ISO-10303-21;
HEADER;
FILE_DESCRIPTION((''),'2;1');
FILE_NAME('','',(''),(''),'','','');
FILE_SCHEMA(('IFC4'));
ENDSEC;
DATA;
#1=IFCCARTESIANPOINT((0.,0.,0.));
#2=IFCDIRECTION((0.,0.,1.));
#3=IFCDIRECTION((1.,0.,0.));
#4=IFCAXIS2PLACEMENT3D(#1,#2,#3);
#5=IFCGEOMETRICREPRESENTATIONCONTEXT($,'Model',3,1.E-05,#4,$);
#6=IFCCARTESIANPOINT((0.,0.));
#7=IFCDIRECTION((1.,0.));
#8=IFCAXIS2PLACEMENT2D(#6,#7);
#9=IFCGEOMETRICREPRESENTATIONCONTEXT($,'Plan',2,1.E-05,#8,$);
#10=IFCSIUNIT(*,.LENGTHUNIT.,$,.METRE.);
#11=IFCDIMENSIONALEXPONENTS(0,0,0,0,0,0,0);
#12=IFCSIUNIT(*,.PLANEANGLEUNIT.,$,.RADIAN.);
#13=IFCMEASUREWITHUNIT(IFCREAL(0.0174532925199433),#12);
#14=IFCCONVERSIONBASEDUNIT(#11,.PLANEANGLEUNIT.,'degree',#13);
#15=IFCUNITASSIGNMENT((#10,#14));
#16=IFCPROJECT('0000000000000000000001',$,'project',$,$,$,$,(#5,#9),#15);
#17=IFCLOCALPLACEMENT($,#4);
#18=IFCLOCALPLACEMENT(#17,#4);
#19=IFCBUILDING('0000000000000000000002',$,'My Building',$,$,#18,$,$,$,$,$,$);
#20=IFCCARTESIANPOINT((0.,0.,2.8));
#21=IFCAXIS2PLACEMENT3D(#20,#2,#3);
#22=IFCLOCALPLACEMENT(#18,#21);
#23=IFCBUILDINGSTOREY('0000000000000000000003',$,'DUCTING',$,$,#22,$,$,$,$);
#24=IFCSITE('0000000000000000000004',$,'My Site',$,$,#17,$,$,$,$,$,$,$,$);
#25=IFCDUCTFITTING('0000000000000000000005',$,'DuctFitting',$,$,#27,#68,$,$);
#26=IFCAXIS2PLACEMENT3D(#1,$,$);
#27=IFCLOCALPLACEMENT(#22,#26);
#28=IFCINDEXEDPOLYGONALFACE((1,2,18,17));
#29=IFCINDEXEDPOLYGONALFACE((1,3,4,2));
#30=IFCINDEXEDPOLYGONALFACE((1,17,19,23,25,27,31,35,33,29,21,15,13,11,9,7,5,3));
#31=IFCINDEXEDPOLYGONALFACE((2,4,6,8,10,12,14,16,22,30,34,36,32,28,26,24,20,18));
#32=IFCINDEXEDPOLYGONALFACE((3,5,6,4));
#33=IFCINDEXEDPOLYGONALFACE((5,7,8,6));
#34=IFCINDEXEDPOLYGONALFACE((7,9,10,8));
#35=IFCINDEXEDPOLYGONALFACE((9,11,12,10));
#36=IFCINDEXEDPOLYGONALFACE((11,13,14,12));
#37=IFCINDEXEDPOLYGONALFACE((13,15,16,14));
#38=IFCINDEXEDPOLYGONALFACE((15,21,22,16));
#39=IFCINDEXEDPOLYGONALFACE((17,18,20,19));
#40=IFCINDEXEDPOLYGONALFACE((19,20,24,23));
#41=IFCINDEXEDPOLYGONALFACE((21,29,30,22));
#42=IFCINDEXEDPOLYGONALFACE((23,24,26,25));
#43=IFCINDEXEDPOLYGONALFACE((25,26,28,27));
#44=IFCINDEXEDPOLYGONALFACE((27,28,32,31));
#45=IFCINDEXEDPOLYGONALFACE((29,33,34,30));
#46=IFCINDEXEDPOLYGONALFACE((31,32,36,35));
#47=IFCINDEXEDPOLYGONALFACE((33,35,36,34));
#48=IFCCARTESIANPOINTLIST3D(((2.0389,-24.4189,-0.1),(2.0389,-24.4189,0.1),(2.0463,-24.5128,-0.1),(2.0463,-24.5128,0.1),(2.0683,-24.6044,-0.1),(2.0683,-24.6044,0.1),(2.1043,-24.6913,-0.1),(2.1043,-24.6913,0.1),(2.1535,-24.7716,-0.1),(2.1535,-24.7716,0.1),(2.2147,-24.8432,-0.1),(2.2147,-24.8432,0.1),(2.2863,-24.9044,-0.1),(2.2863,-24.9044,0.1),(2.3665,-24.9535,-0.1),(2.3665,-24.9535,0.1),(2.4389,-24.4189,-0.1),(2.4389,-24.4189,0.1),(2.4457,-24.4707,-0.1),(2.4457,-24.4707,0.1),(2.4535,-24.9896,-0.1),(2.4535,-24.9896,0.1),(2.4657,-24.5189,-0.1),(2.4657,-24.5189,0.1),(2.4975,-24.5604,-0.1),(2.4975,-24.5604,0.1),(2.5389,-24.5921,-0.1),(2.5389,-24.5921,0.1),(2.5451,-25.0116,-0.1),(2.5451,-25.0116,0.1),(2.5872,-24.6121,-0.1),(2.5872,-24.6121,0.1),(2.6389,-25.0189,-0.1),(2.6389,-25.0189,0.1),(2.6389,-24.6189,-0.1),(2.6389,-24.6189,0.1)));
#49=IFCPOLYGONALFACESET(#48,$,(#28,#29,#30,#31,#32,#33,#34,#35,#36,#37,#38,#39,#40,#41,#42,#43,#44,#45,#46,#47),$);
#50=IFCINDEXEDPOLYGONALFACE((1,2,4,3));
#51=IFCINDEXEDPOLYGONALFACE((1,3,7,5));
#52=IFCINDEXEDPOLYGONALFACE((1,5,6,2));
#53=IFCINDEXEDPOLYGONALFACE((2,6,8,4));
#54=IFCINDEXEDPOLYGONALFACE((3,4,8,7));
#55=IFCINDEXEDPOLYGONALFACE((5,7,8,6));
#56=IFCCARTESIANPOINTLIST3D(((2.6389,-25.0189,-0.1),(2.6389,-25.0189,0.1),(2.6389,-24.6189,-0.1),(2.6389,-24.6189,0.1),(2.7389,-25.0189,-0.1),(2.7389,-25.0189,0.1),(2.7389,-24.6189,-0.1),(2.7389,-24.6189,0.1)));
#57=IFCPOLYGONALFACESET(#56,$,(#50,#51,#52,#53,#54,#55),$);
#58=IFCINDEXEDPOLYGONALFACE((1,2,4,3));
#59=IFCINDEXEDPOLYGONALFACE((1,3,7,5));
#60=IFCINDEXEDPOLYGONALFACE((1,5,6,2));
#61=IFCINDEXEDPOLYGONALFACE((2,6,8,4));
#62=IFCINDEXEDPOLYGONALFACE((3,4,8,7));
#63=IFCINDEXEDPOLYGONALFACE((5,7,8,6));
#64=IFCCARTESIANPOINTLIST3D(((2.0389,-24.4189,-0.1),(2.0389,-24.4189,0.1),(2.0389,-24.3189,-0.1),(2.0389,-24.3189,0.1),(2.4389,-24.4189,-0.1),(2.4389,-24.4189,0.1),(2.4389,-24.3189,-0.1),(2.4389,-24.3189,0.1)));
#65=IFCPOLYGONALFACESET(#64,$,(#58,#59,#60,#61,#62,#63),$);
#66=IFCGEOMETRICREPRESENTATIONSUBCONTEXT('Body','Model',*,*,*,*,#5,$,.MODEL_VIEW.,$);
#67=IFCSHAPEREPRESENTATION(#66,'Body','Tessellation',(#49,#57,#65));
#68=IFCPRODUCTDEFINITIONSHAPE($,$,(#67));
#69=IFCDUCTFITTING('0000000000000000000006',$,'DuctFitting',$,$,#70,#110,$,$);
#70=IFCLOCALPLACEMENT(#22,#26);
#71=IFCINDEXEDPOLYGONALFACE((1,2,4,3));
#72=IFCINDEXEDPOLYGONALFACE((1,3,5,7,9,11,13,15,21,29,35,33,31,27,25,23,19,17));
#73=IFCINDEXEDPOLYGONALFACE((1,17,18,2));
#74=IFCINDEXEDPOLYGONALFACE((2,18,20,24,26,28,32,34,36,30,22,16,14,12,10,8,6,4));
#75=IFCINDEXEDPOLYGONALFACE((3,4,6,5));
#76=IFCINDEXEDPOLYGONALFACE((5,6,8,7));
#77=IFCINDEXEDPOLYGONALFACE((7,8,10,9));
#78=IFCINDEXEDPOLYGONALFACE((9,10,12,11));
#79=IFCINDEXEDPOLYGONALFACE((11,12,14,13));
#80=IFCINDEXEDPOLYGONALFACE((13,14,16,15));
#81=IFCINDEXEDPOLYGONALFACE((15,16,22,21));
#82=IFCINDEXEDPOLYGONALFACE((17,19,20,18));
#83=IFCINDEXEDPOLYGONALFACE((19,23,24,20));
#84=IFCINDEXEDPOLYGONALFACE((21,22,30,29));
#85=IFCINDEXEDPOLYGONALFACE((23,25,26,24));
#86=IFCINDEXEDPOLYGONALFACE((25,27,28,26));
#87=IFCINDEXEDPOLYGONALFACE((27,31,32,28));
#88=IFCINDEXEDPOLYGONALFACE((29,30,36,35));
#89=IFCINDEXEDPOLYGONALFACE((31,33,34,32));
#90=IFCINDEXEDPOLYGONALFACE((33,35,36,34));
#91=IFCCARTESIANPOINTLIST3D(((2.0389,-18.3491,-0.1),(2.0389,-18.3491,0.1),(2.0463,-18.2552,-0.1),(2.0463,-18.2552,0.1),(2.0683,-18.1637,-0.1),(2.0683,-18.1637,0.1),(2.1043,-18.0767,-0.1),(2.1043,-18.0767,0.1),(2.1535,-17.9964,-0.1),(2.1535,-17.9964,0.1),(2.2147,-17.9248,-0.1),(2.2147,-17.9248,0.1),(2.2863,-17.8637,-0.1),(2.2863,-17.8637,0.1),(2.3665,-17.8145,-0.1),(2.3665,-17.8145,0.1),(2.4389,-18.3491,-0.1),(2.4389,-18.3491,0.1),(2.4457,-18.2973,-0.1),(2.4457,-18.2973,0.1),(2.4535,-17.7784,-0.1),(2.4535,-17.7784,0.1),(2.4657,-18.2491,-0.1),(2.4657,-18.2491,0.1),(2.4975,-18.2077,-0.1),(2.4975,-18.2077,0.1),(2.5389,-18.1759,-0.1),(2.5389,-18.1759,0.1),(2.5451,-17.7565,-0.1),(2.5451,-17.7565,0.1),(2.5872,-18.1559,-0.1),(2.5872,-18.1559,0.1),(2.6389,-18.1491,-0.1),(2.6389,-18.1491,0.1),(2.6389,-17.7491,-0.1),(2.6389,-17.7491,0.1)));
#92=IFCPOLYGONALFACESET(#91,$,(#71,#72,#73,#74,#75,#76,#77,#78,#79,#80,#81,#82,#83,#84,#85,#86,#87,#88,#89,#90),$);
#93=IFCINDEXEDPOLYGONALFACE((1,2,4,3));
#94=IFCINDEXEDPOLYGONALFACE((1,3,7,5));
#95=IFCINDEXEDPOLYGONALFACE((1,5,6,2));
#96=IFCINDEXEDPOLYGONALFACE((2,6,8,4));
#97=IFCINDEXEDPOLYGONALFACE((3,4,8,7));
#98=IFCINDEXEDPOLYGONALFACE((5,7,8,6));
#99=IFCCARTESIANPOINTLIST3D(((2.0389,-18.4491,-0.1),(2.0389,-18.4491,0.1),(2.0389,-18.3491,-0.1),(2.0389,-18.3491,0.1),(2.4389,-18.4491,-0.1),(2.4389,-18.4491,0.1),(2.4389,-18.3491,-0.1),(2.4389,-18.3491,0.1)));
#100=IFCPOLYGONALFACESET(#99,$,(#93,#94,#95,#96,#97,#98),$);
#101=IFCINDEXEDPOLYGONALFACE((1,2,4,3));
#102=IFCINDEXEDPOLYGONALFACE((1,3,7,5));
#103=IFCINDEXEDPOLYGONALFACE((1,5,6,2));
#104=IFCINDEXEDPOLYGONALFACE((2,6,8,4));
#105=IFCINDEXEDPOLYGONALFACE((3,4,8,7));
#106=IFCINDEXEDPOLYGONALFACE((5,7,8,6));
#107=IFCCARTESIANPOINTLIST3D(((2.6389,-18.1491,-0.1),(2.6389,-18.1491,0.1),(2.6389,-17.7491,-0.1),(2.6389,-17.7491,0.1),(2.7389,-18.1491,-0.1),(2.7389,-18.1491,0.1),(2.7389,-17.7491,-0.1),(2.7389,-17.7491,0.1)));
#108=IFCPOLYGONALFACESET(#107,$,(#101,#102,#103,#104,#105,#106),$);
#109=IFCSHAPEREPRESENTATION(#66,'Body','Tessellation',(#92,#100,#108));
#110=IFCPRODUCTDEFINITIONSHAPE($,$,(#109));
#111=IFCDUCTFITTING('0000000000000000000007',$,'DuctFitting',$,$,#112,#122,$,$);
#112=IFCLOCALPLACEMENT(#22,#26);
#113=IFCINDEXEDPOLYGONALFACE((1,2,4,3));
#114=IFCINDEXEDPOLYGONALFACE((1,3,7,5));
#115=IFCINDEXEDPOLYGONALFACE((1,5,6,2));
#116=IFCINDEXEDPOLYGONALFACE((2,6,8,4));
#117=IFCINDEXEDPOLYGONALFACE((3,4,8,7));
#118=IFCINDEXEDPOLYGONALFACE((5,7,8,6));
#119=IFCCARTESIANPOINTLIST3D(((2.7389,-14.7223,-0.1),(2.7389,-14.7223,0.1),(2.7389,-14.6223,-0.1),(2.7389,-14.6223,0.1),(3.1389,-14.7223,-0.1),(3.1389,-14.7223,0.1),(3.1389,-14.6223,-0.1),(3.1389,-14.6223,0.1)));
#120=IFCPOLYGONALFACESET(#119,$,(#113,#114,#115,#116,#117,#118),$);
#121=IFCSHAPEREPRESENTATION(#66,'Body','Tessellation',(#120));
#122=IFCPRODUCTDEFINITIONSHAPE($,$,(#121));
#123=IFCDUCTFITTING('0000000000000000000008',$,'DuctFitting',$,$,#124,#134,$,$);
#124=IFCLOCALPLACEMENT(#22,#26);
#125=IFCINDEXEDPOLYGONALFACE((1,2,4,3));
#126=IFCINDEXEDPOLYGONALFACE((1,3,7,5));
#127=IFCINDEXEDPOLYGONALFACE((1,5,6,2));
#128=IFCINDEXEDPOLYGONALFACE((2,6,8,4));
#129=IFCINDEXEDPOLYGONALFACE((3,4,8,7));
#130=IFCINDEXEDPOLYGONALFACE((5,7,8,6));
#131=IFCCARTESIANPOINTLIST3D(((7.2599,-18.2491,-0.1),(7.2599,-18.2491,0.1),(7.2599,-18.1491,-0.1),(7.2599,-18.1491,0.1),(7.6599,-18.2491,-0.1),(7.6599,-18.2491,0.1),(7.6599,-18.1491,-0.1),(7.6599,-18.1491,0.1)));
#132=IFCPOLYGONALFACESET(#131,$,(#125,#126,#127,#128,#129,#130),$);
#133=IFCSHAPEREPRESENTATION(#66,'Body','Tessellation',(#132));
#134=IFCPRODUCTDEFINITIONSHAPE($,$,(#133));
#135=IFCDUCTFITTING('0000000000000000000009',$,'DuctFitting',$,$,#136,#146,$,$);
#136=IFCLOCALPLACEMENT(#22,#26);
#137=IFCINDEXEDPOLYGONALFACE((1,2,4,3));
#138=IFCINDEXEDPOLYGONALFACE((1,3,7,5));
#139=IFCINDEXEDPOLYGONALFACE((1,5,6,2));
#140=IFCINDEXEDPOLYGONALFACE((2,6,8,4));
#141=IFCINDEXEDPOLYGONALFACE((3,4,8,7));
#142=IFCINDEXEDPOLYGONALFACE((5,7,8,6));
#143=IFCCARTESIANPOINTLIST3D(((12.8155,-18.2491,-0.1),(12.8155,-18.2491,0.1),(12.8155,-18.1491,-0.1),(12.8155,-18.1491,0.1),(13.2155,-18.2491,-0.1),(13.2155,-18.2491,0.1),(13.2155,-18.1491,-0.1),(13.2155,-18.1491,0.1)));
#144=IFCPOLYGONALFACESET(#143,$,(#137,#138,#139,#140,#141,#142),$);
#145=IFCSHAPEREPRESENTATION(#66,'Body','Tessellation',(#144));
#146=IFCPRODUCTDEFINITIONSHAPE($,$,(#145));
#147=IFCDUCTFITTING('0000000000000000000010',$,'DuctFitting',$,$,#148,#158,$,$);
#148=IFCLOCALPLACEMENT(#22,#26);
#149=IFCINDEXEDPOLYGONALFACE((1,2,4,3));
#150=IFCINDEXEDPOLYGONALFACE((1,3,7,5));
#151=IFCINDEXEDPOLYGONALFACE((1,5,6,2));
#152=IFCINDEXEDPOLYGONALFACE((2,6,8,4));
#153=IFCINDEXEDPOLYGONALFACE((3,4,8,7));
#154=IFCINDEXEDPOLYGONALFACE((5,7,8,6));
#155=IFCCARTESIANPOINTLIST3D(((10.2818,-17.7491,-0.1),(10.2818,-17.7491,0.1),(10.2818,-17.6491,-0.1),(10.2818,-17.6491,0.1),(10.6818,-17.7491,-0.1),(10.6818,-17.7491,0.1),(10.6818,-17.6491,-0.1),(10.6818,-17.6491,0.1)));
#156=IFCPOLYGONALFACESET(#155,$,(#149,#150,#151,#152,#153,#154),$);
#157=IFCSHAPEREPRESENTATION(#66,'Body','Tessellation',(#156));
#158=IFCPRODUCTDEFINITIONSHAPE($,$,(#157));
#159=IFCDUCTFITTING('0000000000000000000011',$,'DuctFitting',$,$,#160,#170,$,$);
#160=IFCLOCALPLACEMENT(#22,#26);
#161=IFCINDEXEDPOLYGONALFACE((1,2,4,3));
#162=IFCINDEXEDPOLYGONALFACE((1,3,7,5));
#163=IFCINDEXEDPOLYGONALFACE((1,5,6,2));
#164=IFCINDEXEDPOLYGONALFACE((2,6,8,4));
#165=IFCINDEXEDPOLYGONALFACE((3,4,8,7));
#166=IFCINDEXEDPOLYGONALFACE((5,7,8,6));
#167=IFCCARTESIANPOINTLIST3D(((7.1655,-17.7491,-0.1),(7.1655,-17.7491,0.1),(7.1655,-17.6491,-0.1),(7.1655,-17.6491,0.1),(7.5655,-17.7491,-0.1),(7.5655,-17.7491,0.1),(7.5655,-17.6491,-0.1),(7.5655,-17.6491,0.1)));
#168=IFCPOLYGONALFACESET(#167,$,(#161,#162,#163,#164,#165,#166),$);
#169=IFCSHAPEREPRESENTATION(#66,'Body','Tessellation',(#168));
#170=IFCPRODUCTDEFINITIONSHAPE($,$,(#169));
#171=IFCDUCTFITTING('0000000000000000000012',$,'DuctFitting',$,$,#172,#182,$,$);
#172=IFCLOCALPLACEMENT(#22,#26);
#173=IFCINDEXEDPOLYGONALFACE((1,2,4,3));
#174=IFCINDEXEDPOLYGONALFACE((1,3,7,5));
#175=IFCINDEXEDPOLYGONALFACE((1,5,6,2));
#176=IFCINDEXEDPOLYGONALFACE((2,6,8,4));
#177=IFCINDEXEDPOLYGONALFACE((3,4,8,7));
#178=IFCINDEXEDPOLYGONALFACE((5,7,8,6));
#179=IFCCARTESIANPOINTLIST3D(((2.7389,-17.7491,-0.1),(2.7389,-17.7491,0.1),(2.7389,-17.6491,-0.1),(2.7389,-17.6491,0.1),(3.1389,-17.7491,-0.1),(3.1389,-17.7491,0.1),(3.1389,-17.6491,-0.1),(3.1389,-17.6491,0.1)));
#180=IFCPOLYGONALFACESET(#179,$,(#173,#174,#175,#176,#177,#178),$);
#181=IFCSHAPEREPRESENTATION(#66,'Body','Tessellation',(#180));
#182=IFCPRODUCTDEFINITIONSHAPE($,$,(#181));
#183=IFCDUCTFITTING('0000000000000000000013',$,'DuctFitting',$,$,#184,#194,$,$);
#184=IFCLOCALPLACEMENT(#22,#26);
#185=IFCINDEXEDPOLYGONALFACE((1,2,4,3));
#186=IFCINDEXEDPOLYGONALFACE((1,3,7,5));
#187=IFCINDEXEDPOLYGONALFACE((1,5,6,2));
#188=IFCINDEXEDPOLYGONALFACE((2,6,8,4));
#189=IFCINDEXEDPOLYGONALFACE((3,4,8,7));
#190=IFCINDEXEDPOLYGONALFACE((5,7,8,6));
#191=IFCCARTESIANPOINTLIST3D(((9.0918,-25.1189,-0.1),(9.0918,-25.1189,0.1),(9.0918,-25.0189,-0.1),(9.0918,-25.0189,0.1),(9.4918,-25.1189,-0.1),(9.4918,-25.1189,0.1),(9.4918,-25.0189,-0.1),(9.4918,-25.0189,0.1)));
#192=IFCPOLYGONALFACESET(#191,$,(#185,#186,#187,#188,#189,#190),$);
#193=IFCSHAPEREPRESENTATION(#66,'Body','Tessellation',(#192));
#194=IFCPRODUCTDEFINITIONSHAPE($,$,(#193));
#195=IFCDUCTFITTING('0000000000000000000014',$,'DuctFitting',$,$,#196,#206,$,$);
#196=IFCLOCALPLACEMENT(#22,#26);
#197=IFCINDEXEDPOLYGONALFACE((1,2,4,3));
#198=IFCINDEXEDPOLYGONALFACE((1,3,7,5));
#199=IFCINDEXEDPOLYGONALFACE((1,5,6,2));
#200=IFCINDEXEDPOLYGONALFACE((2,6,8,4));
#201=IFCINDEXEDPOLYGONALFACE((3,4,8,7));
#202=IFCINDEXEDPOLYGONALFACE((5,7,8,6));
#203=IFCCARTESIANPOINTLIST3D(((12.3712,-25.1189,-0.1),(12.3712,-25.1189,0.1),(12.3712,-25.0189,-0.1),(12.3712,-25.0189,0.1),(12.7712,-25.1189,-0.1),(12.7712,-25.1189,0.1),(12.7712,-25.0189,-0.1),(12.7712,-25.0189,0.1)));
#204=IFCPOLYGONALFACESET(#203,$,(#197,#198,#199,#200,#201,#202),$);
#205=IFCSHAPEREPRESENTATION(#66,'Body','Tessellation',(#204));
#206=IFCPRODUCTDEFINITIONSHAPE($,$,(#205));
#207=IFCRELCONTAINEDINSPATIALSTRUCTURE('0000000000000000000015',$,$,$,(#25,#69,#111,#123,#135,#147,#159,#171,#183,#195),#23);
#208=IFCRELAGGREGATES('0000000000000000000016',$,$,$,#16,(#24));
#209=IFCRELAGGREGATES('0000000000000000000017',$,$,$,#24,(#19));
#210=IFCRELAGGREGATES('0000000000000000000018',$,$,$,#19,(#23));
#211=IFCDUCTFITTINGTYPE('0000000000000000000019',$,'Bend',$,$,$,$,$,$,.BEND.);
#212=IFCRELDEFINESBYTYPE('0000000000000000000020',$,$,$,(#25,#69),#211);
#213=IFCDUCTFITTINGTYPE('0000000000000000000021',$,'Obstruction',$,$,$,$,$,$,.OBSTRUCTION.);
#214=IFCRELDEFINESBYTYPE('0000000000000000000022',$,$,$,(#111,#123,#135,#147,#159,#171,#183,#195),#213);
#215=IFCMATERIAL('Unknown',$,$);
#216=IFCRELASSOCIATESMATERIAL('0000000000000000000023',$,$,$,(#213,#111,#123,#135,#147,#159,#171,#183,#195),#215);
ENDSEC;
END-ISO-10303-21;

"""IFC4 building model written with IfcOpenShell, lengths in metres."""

from ifc_helpers import new_model, entity, si_unit, converted_unit, frame, origin_with_axes, origin_2d_with_axis, place, context, subcontext, project, spatial, line, arc, indexed_curve, rectangle, outline, extrude, source, transform, mapped, material, material_profile, profile_set, profile_usage, type_object, type_shapes, element, save


model = new_model("IFC4")

# Units and contexts
model_context = context("Model", 3, precision=1e-05, world=origin_with_axes())
plan_context = context("Plan", 2, precision=1e-05, world=origin_2d_with_axis())
body_context = subcontext(model_context, "Body", "Model", "MODEL_VIEW")
ifc_project = project(units=[si_unit("LENGTHUNIT", "METRE"), converted_unit("PLANEANGLEUNIT", "degree", entity("IfcReal", 0.0174532925199433), si_unit("PLANEANGLEUNIT", "RADIAN"), dimensions=[0, 0, 0, 0, 0, 0, 0])], contexts=[model_context, plan_context])

# Site, building, storey
site_placement = place(None, origin_with_axes())
site = spatial("IfcSite", under=ifc_project, at=site_placement, Name="My Site")
building_placement = place(site_placement, origin_with_axes())
building = spatial("IfcBuilding", under=site, at=building_placement, Name="My Building")
storey_placement = place(building_placement, frame((0.0, 0.0, 2.8), z_axis=(0.0, 0.0, 1.0), x_axis=(1.0, 0.0, 0.0)))
storey = spatial("IfcBuildingStorey", under=building, at=storey_placement, Name="DUCTING")

# Shared definitions
ifc_material = material(Name="Unknown")

# Duct fittings
duct_fitting_type_1 = type_object("IfcDuctFittingType", Name="Bend", PredefinedType="BEND")
shared_shape = source(origin_with_axes(), body_context, "Body", "SweptSolid", [
    extrude(outline(indexed_curve([(0.2, 0.0), (0.2586, -0.1414), (0.4, -0.2), (0.4, -0.6), (-0.0243, -0.4243), (-0.2, 0.0)], segments=[arc(1, 2, 3), line(3, 4), arc(4, 5, 6), line(6, 1)])), frame((0.0, -0.1, -0.1), z_axis=(0.0, -1.0, 0.0), x_axis=(1.0, 0.0, 0.0)), (0.0, 0.0, -1.0), 0.2),
    extrude(rectangle(XDim=0.4, YDim=0.2), origin_with_axes(), (0.0, 0.0, -1.0), 0.1),
    extrude(rectangle(XDim=0.4, YDim=0.2), frame((0.4, 0.0, -0.5), z_axis=(1.0, 0.0, 0.0), x_axis=(0.0, 0.0, 1.0)), (0.0, 0.0, 1.0), 0.1),
])
type_shapes(duct_fitting_type_1, [shared_shape])
for number, where, z_axis, x_axis, name in (
    (1, (2.7389, -24.8189, 0.0), (1.0, 0.0, 0.0), (0.0, 1.0, 0.0), "DuctFitting"),
    (2, (2.2389, -18.4491, 0.0), (0.0, -1.0, 0.0), (1.0, 0.0, 0.0), "DuctFitting"),
):
    element("IfcDuctFitting", number, at=place(storey_placement, frame(where, z_axis=z_axis, x_axis=x_axis)), inside=storey, type_object=duct_fitting_type_1, Name=name, context=body_context, shape_type="MappedRepresentation", body=[
        mapped(shared_shape, transform((0.0, 0.0, 0.0), x_axis=(1.0, 0.0, 0.0), y_axis=(0.0, 1.0, 0.0), z_axis=(0.0, 0.0, 1.0), scale=1.0)),
    ])
ifc_material_profile_1 = material_profile(ifc_material, rectangle(XDim=0.4, YDim=0.2))
ifc_profile_set_1 = profile_set([ifc_material_profile_1])
ifc_profile_usage_1 = profile_usage(ifc_profile_set_1, cardinal=5)
duct_fitting_type_2 = type_object("IfcDuctFittingType", Name="Obstruction", PredefinedType="OBSTRUCTION", material=ifc_profile_set_1)
duct_fitting_1_placement = place(storey_placement, frame((2.9389, -14.7223, 0.0), z_axis=(0.0, 1.0, 0.0), x_axis=(-1.0, 0.0, 0.0)))
element("IfcDuctFitting", 3, at=duct_fitting_1_placement, inside=storey, type_object=duct_fitting_type_2, material=ifc_profile_usage_1, Name="DuctFitting", context=body_context, shape_type="SweptSolid", body=[
    extrude(rectangle(XDim=0.4, YDim=0.2), origin_with_axes(), (0.0, 0.0, 1.0), 0.1),
])
ifc_profile_usage_2 = profile_usage(ifc_profile_set_1, cardinal=5)
duct_fitting_2_placement = place(storey_placement, frame((7.4599, -18.1491, 0.0), z_axis=(0.000001, -1.0, 0.0), x_axis=(1.0, 0.000001, 0.0)))
element("IfcDuctFitting", 4, at=duct_fitting_2_placement, inside=storey, type_object=duct_fitting_type_2, material=ifc_profile_usage_2, Name="DuctFitting", context=body_context, shape_type="SweptSolid", body=[
    extrude(rectangle(XDim=0.4, YDim=0.2), origin_with_axes(), (0.0, 0.0, 1.0), 0.1),
])
ifc_profile_usage_3 = profile_usage(ifc_profile_set_1, cardinal=5)
duct_fitting_3_placement = place(storey_placement, frame((13.0155, -18.1491, 0.0), z_axis=(0.000001, -1.0, 0.0), x_axis=(1.0, 0.000001, 0.0)))
element("IfcDuctFitting", 5, at=duct_fitting_3_placement, inside=storey, type_object=duct_fitting_type_2, material=ifc_profile_usage_3, Name="DuctFitting", context=body_context, shape_type="SweptSolid", body=[
    extrude(rectangle(XDim=0.4, YDim=0.2), origin_with_axes(), (0.0, 0.0, 1.0), 0.1),
])
ifc_profile_usage_4 = profile_usage(ifc_profile_set_1, cardinal=5)
duct_fitting_4_placement = place(storey_placement, frame((10.4818, -17.6491, 0.0), z_axis=(0.0, -1.0, 0.0), x_axis=(1.0, 0.0, 0.0)))
element("IfcDuctFitting", 6, at=duct_fitting_4_placement, inside=storey, type_object=duct_fitting_type_2, material=ifc_profile_usage_4, Name="DuctFitting", context=body_context, shape_type="SweptSolid", body=[
    extrude(rectangle(XDim=0.4, YDim=0.2), origin_with_axes(), (0.0, 0.0, 1.0), 0.1),
])
ifc_profile_usage_5 = profile_usage(ifc_profile_set_1, cardinal=5)
duct_fitting_5_placement = place(storey_placement, frame((7.3655, -17.6491, 0.0), z_axis=(0.0, -1.0, 0.0), x_axis=(1.0, 0.0, 0.0)))
element("IfcDuctFitting", 7, at=duct_fitting_5_placement, inside=storey, type_object=duct_fitting_type_2, material=ifc_profile_usage_5, Name="DuctFitting", context=body_context, shape_type="SweptSolid", body=[
    extrude(rectangle(XDim=0.4, YDim=0.2), origin_with_axes(), (0.0, 0.0, 1.0), 0.1),
])
ifc_profile_usage_6 = profile_usage(ifc_profile_set_1, cardinal=5)
duct_fitting_6_placement = place(storey_placement, frame((2.9389, -17.6491, 0.0), z_axis=(0.0, -1.0, 0.0), x_axis=(1.0, 0.0, 0.0)))
element("IfcDuctFitting", 8, at=duct_fitting_6_placement, inside=storey, type_object=duct_fitting_type_2, material=ifc_profile_usage_6, Name="DuctFitting", context=body_context, shape_type="SweptSolid", body=[
    extrude(rectangle(XDim=0.4, YDim=0.2), origin_with_axes(), (0.0, 0.0, 1.0), 0.1),
])
ifc_profile_usage_7 = profile_usage(ifc_profile_set_1, cardinal=5)
duct_fitting_7_placement = place(storey_placement, frame((9.2918, -25.0189, 0.0), z_axis=(0.000001, -1.0, 0.0), x_axis=(1.0, 0.000001, 0.0)))
element("IfcDuctFitting", 9, at=duct_fitting_7_placement, inside=storey, type_object=duct_fitting_type_2, material=ifc_profile_usage_7, Name="DuctFitting", context=body_context, shape_type="SweptSolid", body=[
    extrude(rectangle(XDim=0.4, YDim=0.2), origin_with_axes(), (0.0, 0.0, 1.0), 0.1),
])
ifc_profile_usage_8 = profile_usage(ifc_profile_set_1, cardinal=5)
duct_fitting_8_placement = place(storey_placement, frame((12.5712, -25.0189, 0.0), z_axis=(0.000001, -1.0, 0.0), x_axis=(1.0, 0.000001, 0.0)))
element("IfcDuctFitting", 10, at=duct_fitting_8_placement, inside=storey, type_object=duct_fitting_type_2, material=ifc_profile_usage_8, Name="DuctFitting", context=body_context, shape_type="SweptSolid", body=[
    extrude(rectangle(XDim=0.4, YDim=0.2), origin_with_axes(), (0.0, 0.0, 1.0), 0.1),
])

save(model, "model.ifc")
